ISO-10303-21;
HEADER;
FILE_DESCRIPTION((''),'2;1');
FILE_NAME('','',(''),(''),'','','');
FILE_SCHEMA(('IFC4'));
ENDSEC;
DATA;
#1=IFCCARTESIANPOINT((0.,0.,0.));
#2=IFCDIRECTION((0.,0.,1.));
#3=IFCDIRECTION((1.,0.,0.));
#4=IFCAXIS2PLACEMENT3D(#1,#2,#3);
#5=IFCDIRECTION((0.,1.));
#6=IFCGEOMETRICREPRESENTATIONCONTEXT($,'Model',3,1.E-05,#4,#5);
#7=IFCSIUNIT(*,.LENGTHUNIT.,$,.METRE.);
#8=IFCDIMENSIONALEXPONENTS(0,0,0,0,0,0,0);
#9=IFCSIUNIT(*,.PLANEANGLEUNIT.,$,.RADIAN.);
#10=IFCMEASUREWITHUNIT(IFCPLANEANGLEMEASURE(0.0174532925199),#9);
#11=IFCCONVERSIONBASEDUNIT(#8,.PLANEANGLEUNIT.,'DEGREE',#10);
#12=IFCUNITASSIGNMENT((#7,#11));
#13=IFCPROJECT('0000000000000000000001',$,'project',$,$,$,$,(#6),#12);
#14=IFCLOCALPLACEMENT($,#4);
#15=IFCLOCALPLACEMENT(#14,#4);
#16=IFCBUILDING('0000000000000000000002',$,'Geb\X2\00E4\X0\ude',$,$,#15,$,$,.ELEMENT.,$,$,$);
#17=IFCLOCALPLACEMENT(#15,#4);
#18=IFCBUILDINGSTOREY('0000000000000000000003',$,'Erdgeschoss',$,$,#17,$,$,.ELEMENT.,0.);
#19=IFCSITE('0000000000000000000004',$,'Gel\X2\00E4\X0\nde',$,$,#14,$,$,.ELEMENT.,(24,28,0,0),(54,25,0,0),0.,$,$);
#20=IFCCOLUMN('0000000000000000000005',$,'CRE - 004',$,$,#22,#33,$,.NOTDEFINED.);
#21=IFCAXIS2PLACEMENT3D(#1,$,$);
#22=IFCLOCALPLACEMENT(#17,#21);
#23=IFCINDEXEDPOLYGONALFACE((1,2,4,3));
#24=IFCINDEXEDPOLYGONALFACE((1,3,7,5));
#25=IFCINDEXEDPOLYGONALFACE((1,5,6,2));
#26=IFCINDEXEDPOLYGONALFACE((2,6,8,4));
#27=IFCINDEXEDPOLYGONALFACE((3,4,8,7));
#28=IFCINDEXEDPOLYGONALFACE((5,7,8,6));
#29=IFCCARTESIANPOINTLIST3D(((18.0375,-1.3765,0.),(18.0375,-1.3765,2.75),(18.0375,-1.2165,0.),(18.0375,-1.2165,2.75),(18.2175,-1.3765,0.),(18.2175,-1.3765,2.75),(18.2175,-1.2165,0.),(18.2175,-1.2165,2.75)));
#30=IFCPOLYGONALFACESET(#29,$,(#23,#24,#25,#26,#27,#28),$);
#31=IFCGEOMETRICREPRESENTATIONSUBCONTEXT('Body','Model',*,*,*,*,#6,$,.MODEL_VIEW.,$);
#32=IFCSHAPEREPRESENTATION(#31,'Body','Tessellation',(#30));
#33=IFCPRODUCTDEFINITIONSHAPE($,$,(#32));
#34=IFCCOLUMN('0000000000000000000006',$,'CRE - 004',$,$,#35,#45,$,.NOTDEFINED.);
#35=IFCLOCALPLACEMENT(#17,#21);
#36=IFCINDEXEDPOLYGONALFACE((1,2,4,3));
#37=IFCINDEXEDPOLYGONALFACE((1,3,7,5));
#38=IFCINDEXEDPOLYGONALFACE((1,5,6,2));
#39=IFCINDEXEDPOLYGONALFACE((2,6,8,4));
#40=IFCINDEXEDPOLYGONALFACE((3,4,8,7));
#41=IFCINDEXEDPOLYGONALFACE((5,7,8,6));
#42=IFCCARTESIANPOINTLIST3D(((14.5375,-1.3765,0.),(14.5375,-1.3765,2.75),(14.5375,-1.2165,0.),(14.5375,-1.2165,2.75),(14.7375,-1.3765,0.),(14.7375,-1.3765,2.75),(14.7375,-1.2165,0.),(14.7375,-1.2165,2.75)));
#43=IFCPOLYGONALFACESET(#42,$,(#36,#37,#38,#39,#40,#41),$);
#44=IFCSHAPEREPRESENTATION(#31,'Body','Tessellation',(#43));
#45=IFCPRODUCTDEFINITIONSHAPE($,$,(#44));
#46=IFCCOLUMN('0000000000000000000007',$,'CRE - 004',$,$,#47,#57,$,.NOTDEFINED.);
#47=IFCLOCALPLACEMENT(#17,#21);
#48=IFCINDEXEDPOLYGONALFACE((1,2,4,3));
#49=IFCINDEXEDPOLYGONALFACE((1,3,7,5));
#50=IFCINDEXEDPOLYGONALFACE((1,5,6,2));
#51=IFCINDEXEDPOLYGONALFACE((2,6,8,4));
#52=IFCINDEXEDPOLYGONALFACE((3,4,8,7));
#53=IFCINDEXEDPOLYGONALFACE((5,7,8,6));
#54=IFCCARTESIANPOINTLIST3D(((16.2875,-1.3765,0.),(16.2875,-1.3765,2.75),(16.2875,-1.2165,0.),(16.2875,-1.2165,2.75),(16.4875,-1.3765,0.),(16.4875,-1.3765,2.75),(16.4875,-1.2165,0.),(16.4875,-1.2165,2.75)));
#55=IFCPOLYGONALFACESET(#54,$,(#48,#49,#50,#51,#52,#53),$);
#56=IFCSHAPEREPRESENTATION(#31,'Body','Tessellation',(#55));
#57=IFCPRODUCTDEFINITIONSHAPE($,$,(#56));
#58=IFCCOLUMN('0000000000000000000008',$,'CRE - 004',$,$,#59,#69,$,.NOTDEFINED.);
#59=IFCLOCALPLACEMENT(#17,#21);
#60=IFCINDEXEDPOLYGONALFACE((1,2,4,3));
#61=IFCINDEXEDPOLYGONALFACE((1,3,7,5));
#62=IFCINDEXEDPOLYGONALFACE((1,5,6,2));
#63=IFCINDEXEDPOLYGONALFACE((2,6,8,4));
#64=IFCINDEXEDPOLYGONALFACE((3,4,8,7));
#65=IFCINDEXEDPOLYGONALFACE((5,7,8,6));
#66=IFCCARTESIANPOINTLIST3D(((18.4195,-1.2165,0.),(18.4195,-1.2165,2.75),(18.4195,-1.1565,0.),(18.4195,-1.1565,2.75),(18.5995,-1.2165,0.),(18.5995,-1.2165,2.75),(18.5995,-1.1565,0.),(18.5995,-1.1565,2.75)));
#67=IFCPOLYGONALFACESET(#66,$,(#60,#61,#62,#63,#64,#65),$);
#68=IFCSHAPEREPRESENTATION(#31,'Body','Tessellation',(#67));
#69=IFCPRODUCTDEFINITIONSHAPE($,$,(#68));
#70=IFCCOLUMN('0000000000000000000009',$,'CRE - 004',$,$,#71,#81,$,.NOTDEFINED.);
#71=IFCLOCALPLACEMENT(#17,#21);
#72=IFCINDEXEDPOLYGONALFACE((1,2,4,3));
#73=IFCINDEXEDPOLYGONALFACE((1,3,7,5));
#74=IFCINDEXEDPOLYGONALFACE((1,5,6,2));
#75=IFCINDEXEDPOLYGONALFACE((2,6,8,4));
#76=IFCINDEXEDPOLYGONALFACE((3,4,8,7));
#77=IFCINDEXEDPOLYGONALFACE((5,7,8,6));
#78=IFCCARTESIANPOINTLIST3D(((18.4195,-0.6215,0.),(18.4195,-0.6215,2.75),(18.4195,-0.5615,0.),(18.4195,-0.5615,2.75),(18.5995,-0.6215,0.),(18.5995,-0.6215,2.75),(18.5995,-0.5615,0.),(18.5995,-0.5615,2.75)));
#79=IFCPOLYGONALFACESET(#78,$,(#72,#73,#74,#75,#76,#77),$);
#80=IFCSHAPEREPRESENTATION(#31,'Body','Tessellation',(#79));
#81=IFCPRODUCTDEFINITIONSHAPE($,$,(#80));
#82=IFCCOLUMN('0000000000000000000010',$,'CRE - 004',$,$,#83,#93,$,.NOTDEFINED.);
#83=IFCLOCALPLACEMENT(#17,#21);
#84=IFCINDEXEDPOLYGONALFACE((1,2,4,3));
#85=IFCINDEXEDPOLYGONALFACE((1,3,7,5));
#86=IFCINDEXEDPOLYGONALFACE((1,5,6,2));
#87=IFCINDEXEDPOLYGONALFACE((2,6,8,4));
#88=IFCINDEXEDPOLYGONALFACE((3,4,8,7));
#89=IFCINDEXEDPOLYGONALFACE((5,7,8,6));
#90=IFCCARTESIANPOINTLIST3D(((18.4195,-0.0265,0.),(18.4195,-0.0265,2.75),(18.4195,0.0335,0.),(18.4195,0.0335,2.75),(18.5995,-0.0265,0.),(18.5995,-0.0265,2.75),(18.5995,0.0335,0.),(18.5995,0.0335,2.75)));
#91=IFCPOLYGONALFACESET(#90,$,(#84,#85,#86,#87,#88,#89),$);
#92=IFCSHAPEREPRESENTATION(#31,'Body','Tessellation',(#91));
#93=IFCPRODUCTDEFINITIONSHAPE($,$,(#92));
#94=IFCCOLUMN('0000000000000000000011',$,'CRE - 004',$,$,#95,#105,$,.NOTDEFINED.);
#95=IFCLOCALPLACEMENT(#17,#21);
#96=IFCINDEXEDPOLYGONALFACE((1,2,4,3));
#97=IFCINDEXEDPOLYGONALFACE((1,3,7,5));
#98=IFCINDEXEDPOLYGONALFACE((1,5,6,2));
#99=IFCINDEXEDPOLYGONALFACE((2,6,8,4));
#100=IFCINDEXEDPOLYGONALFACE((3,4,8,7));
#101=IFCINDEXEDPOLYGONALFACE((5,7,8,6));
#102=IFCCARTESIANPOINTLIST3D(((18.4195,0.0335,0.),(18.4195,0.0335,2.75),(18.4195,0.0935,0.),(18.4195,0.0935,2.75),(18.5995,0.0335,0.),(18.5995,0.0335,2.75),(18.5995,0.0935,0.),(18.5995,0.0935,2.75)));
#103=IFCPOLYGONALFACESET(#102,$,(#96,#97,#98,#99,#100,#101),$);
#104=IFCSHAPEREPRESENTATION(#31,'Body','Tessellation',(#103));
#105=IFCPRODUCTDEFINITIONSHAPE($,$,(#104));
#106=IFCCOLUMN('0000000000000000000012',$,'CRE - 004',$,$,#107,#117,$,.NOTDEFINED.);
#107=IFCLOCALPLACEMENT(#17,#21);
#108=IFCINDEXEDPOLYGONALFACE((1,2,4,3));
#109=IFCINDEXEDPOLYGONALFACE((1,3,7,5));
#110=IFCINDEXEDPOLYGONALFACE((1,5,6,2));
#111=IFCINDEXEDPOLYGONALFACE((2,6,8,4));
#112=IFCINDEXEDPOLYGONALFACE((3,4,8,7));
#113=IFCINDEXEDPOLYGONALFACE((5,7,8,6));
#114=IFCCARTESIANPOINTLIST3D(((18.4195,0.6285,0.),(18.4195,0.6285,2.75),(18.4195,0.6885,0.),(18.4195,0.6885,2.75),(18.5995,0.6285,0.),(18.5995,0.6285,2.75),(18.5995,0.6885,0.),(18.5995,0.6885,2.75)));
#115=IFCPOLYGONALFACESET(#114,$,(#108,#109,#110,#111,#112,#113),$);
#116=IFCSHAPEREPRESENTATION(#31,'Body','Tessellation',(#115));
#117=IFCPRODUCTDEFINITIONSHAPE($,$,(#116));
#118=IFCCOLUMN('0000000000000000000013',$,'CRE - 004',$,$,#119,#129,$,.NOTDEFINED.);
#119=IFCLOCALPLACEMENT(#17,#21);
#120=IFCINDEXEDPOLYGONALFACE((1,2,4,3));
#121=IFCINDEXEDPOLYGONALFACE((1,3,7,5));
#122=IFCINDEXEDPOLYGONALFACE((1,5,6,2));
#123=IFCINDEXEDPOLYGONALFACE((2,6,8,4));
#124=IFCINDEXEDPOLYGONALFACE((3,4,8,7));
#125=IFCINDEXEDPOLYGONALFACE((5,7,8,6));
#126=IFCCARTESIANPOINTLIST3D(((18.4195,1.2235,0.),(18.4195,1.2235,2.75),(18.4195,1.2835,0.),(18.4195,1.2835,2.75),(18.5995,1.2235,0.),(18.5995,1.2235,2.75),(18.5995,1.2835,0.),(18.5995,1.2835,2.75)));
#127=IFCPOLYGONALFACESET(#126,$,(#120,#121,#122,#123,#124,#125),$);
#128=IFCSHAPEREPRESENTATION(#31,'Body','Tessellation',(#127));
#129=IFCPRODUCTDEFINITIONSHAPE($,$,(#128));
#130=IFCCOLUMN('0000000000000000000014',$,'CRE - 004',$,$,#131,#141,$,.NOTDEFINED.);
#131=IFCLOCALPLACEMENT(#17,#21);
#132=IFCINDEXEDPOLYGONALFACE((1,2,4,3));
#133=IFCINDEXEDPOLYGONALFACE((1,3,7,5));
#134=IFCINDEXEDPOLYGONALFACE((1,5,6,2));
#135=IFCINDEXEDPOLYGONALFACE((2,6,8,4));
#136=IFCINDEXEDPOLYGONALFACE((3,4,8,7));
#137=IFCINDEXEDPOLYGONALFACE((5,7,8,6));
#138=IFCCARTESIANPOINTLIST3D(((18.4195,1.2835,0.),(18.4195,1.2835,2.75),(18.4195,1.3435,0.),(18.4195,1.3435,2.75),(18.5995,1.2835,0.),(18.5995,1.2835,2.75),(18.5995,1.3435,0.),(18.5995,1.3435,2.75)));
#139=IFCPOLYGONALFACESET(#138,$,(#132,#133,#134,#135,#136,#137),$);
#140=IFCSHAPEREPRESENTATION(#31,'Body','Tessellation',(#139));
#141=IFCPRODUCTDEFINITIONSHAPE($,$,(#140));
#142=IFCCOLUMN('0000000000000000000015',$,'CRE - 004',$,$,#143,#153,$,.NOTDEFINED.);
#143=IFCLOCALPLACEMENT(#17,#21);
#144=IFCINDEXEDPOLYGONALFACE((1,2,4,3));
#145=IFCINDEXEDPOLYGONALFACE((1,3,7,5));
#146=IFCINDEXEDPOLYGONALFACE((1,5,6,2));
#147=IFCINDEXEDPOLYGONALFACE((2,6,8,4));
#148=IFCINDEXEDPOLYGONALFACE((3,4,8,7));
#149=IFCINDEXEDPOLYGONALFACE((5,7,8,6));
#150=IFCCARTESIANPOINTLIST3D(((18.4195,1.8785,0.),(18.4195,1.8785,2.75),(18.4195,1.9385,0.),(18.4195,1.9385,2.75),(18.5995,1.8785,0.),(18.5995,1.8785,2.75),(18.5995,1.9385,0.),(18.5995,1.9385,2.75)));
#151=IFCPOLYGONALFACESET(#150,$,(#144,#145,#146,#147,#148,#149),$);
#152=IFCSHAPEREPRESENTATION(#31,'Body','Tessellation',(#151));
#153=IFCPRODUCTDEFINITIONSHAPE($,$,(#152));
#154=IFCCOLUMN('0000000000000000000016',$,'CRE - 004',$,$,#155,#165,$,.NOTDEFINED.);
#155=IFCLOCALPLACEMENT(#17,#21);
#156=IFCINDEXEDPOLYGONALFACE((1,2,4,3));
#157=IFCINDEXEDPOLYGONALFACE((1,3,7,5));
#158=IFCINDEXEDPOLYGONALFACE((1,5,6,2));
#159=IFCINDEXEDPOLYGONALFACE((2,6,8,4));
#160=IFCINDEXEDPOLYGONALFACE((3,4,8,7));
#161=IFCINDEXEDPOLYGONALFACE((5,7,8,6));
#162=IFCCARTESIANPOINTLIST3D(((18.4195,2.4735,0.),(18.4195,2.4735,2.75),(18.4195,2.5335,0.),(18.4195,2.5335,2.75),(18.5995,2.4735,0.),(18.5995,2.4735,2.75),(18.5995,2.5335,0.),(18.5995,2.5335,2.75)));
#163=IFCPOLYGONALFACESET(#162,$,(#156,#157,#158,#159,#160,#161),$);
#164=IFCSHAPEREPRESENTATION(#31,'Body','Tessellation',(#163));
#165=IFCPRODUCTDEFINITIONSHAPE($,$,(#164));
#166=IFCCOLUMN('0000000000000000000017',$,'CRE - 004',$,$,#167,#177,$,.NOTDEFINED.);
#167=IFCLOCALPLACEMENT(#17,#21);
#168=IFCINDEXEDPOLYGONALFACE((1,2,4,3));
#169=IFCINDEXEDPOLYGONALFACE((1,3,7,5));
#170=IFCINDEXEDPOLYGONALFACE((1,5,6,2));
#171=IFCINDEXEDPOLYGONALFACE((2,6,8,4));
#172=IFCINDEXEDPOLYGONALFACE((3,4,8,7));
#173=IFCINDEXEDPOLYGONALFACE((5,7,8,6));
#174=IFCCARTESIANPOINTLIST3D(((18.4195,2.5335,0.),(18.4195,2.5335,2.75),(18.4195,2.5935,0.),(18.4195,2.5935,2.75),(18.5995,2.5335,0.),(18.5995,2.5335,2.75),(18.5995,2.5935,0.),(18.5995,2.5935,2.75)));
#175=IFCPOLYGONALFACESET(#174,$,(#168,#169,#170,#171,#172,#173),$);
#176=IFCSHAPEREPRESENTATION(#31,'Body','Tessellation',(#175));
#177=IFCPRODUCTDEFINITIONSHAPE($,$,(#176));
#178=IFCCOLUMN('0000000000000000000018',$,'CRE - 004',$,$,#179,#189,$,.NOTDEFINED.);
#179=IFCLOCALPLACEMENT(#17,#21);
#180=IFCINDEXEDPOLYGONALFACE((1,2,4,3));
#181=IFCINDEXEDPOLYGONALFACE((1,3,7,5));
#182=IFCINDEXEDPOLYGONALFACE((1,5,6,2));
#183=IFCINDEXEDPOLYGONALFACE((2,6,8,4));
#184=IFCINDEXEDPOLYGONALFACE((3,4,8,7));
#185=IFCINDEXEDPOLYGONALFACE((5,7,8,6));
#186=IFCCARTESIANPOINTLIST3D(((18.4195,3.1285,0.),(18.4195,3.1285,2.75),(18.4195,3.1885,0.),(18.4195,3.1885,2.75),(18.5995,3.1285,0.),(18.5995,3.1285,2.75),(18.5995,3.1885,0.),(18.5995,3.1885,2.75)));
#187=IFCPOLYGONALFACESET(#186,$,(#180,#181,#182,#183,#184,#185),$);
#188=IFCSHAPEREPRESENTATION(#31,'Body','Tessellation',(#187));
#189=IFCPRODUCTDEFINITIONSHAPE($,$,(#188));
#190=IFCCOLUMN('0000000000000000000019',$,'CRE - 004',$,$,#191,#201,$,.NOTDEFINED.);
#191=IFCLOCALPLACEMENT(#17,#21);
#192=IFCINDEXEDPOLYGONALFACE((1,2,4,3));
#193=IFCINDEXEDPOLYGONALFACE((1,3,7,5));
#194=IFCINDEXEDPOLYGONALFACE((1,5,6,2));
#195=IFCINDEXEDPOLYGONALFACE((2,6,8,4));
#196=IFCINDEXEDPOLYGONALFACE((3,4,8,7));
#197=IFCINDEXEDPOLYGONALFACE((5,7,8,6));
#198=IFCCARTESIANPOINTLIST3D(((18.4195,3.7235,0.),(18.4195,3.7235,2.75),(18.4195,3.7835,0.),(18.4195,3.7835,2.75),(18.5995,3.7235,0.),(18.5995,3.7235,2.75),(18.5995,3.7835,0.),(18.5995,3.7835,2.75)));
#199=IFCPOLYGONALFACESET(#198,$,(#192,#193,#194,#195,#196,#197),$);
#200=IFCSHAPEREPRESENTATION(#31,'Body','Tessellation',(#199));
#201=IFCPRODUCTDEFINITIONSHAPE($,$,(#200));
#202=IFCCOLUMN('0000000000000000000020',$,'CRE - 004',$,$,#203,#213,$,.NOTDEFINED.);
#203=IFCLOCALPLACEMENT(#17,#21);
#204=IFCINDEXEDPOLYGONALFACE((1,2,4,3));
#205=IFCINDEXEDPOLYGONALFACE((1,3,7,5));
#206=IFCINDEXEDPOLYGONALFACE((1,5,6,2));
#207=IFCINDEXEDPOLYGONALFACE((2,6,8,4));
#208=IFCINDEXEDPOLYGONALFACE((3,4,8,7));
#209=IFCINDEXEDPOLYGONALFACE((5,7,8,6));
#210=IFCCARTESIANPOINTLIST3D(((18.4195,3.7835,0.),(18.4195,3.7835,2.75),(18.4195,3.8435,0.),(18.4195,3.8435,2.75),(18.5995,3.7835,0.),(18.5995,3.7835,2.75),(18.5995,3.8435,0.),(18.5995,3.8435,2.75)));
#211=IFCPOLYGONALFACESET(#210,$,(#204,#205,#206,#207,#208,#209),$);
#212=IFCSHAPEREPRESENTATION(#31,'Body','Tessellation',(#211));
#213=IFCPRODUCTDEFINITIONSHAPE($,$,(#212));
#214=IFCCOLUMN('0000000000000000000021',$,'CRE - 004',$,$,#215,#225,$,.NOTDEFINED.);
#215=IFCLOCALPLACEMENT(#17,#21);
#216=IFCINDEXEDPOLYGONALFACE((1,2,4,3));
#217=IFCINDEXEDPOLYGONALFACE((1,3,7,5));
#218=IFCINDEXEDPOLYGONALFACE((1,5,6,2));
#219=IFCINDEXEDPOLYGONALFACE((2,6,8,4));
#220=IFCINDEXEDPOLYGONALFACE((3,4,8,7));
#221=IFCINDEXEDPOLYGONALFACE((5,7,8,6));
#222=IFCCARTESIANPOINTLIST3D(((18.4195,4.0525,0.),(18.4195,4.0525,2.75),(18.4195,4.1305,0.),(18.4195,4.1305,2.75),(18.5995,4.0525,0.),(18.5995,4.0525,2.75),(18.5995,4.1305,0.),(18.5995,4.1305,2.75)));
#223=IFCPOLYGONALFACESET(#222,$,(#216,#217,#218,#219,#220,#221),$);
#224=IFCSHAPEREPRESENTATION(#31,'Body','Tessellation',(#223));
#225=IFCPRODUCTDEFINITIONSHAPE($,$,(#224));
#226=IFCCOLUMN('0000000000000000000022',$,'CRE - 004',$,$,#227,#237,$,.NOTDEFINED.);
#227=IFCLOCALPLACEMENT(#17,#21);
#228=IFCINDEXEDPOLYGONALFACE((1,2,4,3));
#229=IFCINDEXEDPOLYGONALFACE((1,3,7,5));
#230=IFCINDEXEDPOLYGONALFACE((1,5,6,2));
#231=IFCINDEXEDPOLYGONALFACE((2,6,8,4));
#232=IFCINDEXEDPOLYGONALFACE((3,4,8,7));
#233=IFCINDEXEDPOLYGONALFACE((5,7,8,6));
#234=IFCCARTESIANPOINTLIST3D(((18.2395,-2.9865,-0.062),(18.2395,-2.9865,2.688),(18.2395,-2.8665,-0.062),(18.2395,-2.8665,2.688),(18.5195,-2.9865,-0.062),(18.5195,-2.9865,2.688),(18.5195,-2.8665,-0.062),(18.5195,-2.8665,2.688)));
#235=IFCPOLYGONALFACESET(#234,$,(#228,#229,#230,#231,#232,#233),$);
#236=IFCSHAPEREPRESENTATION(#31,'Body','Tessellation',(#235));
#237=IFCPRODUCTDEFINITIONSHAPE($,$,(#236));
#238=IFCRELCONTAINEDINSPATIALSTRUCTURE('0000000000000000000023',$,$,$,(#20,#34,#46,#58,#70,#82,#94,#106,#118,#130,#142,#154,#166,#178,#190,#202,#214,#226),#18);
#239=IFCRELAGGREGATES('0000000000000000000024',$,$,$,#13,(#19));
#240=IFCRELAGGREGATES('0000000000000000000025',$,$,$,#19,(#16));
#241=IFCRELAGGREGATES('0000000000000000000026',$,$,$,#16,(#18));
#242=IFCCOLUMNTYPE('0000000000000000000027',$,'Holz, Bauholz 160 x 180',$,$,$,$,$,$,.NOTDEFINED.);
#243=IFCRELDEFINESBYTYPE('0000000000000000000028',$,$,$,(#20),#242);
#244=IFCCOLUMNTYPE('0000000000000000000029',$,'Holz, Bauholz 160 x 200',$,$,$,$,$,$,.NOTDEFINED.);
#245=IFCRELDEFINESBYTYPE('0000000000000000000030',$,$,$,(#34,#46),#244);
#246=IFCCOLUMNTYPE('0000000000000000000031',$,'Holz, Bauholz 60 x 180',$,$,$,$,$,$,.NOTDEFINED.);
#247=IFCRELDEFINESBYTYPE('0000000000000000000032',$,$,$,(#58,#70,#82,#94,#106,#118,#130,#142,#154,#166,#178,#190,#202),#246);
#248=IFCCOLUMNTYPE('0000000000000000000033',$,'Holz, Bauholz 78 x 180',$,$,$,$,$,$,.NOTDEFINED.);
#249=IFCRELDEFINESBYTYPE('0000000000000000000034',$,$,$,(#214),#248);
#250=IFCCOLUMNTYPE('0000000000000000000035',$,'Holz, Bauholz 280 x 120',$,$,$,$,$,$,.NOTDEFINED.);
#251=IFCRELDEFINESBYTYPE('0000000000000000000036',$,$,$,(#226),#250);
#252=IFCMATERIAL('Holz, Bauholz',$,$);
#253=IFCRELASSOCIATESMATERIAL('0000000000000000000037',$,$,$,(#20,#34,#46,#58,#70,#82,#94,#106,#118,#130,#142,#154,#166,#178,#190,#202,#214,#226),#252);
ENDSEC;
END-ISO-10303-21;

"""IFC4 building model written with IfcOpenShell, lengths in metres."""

from ifc_helpers import new_model, entity, si_unit, converted_unit, direction, frame, origin_with_axes, origin_2d_with_axis, place, context, subcontext, project, spatial, rectangle, extrude, material, type_object, element, save


model = new_model("IFC4")

# Units and contexts
model_context = context("Model", 3, precision=1e-05, world=origin_with_axes(), true_north=direction((0.0, 1.0)))
body_context = subcontext(model_context, "Body", "Model", "MODEL_VIEW")
ifc_project = project(units=[si_unit("LENGTHUNIT", "METRE"), converted_unit("PLANEANGLEUNIT", "DEGREE", entity("IfcPlaneAngleMeasure", 0.0174532925199), si_unit("PLANEANGLEUNIT", "RADIAN"), dimensions=[0, 0, 0, 0, 0, 0, 0])], contexts=[model_context])

# Site, building, storey
site_placement = place(None, origin_with_axes())
site = spatial("IfcSite", under=ifc_project, at=site_placement, Name="Gelände", CompositionType="ELEMENT", RefLatitude=(24, 28, 0, 0), RefLongitude=(54, 25, 0, 0), RefElevation=0.0)
building_placement = place(site_placement, origin_with_axes())
building = spatial("IfcBuilding", under=site, at=building_placement, Name="Gebäude", CompositionType="ELEMENT")
storey_placement = place(building_placement, origin_with_axes())
storey = spatial("IfcBuildingStorey", under=building, at=storey_placement, Name="Erdgeschoss", CompositionType="ELEMENT", Elevation=0.0)

# Columns
ifc_material_1 = material(Name="Holz, Bauholz")
column_type_1 = type_object("IfcColumnType", Name="Holz, Bauholz 160 x 180", PredefinedType="NOTDEFINED")
column_1_placement = place(storey_placement, frame((18.1275, -1.2965, 0.0), z_axis=(0.0, 0.0, 1.0), x_axis=(1.0, 0.0, 0.0)))
element("IfcColumn", 1, at=column_1_placement, inside=storey, type_object=column_type_1, material=ifc_material_1, Name="CRE - 004", PredefinedType="NOTDEFINED", context=body_context, shape_type="SweptSolid", body=[
    extrude(rectangle(XDim=0.16, YDim=0.18, at=origin_2d_with_axis()), frame((0.0, 0.0, 0.0), z_axis=(0.0, 0.0, 1.0), x_axis=(0.0, 1.0, 0.0)), (0.0, 0.0, 1.0), 2.75),
])
column_type_2 = type_object("IfcColumnType", Name="Holz, Bauholz 160 x 200", PredefinedType="NOTDEFINED")
for number, where, z_axis, x_axis, name in (
    (2, (14.6375, -1.2965, 0.0), (0.0, 0.0, 1.0), (1.0, 0.0, 0.0), "CRE - 004"),
    (3, (16.3875, -1.2965, 0.0), (0.0, 0.0, 1.0), (1.0, 0.0, 0.0), "CRE - 004"),
):
    element("IfcColumn", number, at=place(storey_placement, frame(where, z_axis=z_axis, x_axis=x_axis)), inside=storey, type_object=column_type_2, material=ifc_material_1, Name=name, PredefinedType="NOTDEFINED", context=body_context, shape_type="SweptSolid", body=[
        extrude(rectangle(XDim=0.16, YDim=0.2, at=origin_2d_with_axis()), frame((0.0, 0.0, 0.0), z_axis=(0.0, 0.0, 1.0), x_axis=(0.0, 1.0, 0.0)), (0.0, 0.0, 1.0), 2.75),
    ])
column_type_3 = type_object("IfcColumnType", Name="Holz, Bauholz 60 x 180", PredefinedType="NOTDEFINED")
for number, where, z_axis, x_axis, name in (
    (4, (18.5095, -1.1865, 0.0), (0.0, 0.0, 1.0), (1.0, 0.0, 0.0), "CRE - 004"),
    (5, (18.5095, -0.5915, 0.0), (0.0, 0.0, 1.0), (1.0, 0.0, 0.0), "CRE - 004"),
    (6, (18.5095, 0.0035, 0.0), (0.0, 0.0, 1.0), (1.0, 0.0, 0.0), "CRE - 004"),
    (7, (18.5095, 0.0635, 0.0), (0.0, 0.0, 1.0), (1.0, 0.0, 0.0), "CRE - 004"),
    (8, (18.5095, 0.6585, 0.0), (0.0, 0.0, 1.0), (1.0, 0.0, 0.0), "CRE - 004"),
    (9, (18.5095, 1.2535, 0.0), (0.0, 0.0, 1.0), (1.0, 0.0, 0.0), "CRE - 004"),
    (10, (18.5095, 1.3135, 0.0), (0.0, 0.0, 1.0), (1.0, 0.0, 0.0), "CRE - 004"),
    (11, (18.5095, 1.9085, 0.0), (0.0, 0.0, 1.0), (1.0, 0.0, 0.0), "CRE - 004"),
    (12, (18.5095, 2.5035, 0.0), (0.0, 0.0, 1.0), (1.0, 0.0, 0.0), "CRE - 004"),
    (13, (18.5095, 2.5635, 0.0), (0.0, 0.0, 1.0), (1.0, 0.0, 0.0), "CRE - 004"),
    (14, (18.5095, 3.1585, 0.0), (0.0, 0.0, 1.0), (1.0, 0.0, 0.0), "CRE - 004"),
    (15, (18.5095, 3.7535, 0.0), (0.0, 0.0, 1.0), (1.0, 0.0, 0.0), "CRE - 004"),
    (16, (18.5095, 3.8135, 0.0), (0.0, 0.0, 1.0), (1.0, 0.0, 0.0), "CRE - 004"),
):
    element("IfcColumn", number, at=place(storey_placement, frame(where, z_axis=z_axis, x_axis=x_axis)), inside=storey, type_object=column_type_3, material=ifc_material_1, Name=name, PredefinedType="NOTDEFINED", context=body_context, shape_type="SweptSolid", body=[
        extrude(rectangle(XDim=0.06, YDim=0.18, at=origin_2d_with_axis()), frame((0.0, 0.0, 0.0), z_axis=(0.0, 0.0, 1.0), x_axis=(0.0, 1.0, 0.0)), (0.0, 0.0, 1.0), 2.75),
    ])
column_type_4 = type_object("IfcColumnType", Name="Holz, Bauholz 78 x 180", PredefinedType="NOTDEFINED")
column_2_placement = place(storey_placement, frame((18.5095, 4.0915, 0.0), z_axis=(0.0, 0.0, 1.0), x_axis=(1.0, 0.0, 0.0)))
element("IfcColumn", 17, at=column_2_placement, inside=storey, type_object=column_type_4, material=ifc_material_1, Name="CRE - 004", PredefinedType="NOTDEFINED", context=body_context, shape_type="SweptSolid", body=[
    extrude(rectangle(XDim=0.078, YDim=0.18, at=origin_2d_with_axis()), frame((0.0, 0.0, 0.0), z_axis=(0.0, 0.0, 1.0), x_axis=(0.0, 1.0, 0.0)), (0.0, 0.0, 1.0), 2.75),
])
column_type_5 = type_object("IfcColumnType", Name="Holz, Bauholz 280 x 120", PredefinedType="NOTDEFINED")
for number, where, z_axis, x_axis, name in (
    (18, (18.3795, -2.9265, -0.062), (0.0, 0.0, 1.0), (0.0, 1.0, 0.0), "CRE - 004"),
):
    element("IfcColumn", number, at=place(storey_placement, frame(where, z_axis=z_axis, x_axis=x_axis)), inside=storey, type_object=column_type_5, material=ifc_material_1, Name=name, PredefinedType="NOTDEFINED", context=body_context, shape_type="SweptSolid", body=[
        extrude(rectangle(XDim=0.28, YDim=0.12, at=origin_2d_with_axis()), frame((0.0, 0.0, 0.0), z_axis=(0.0, 0.0, 1.0), x_axis=(0.0, 1.0, 0.0)), (0.0, 0.0, 1.0), 2.75),
    ])

save(model, "model.ifc")
